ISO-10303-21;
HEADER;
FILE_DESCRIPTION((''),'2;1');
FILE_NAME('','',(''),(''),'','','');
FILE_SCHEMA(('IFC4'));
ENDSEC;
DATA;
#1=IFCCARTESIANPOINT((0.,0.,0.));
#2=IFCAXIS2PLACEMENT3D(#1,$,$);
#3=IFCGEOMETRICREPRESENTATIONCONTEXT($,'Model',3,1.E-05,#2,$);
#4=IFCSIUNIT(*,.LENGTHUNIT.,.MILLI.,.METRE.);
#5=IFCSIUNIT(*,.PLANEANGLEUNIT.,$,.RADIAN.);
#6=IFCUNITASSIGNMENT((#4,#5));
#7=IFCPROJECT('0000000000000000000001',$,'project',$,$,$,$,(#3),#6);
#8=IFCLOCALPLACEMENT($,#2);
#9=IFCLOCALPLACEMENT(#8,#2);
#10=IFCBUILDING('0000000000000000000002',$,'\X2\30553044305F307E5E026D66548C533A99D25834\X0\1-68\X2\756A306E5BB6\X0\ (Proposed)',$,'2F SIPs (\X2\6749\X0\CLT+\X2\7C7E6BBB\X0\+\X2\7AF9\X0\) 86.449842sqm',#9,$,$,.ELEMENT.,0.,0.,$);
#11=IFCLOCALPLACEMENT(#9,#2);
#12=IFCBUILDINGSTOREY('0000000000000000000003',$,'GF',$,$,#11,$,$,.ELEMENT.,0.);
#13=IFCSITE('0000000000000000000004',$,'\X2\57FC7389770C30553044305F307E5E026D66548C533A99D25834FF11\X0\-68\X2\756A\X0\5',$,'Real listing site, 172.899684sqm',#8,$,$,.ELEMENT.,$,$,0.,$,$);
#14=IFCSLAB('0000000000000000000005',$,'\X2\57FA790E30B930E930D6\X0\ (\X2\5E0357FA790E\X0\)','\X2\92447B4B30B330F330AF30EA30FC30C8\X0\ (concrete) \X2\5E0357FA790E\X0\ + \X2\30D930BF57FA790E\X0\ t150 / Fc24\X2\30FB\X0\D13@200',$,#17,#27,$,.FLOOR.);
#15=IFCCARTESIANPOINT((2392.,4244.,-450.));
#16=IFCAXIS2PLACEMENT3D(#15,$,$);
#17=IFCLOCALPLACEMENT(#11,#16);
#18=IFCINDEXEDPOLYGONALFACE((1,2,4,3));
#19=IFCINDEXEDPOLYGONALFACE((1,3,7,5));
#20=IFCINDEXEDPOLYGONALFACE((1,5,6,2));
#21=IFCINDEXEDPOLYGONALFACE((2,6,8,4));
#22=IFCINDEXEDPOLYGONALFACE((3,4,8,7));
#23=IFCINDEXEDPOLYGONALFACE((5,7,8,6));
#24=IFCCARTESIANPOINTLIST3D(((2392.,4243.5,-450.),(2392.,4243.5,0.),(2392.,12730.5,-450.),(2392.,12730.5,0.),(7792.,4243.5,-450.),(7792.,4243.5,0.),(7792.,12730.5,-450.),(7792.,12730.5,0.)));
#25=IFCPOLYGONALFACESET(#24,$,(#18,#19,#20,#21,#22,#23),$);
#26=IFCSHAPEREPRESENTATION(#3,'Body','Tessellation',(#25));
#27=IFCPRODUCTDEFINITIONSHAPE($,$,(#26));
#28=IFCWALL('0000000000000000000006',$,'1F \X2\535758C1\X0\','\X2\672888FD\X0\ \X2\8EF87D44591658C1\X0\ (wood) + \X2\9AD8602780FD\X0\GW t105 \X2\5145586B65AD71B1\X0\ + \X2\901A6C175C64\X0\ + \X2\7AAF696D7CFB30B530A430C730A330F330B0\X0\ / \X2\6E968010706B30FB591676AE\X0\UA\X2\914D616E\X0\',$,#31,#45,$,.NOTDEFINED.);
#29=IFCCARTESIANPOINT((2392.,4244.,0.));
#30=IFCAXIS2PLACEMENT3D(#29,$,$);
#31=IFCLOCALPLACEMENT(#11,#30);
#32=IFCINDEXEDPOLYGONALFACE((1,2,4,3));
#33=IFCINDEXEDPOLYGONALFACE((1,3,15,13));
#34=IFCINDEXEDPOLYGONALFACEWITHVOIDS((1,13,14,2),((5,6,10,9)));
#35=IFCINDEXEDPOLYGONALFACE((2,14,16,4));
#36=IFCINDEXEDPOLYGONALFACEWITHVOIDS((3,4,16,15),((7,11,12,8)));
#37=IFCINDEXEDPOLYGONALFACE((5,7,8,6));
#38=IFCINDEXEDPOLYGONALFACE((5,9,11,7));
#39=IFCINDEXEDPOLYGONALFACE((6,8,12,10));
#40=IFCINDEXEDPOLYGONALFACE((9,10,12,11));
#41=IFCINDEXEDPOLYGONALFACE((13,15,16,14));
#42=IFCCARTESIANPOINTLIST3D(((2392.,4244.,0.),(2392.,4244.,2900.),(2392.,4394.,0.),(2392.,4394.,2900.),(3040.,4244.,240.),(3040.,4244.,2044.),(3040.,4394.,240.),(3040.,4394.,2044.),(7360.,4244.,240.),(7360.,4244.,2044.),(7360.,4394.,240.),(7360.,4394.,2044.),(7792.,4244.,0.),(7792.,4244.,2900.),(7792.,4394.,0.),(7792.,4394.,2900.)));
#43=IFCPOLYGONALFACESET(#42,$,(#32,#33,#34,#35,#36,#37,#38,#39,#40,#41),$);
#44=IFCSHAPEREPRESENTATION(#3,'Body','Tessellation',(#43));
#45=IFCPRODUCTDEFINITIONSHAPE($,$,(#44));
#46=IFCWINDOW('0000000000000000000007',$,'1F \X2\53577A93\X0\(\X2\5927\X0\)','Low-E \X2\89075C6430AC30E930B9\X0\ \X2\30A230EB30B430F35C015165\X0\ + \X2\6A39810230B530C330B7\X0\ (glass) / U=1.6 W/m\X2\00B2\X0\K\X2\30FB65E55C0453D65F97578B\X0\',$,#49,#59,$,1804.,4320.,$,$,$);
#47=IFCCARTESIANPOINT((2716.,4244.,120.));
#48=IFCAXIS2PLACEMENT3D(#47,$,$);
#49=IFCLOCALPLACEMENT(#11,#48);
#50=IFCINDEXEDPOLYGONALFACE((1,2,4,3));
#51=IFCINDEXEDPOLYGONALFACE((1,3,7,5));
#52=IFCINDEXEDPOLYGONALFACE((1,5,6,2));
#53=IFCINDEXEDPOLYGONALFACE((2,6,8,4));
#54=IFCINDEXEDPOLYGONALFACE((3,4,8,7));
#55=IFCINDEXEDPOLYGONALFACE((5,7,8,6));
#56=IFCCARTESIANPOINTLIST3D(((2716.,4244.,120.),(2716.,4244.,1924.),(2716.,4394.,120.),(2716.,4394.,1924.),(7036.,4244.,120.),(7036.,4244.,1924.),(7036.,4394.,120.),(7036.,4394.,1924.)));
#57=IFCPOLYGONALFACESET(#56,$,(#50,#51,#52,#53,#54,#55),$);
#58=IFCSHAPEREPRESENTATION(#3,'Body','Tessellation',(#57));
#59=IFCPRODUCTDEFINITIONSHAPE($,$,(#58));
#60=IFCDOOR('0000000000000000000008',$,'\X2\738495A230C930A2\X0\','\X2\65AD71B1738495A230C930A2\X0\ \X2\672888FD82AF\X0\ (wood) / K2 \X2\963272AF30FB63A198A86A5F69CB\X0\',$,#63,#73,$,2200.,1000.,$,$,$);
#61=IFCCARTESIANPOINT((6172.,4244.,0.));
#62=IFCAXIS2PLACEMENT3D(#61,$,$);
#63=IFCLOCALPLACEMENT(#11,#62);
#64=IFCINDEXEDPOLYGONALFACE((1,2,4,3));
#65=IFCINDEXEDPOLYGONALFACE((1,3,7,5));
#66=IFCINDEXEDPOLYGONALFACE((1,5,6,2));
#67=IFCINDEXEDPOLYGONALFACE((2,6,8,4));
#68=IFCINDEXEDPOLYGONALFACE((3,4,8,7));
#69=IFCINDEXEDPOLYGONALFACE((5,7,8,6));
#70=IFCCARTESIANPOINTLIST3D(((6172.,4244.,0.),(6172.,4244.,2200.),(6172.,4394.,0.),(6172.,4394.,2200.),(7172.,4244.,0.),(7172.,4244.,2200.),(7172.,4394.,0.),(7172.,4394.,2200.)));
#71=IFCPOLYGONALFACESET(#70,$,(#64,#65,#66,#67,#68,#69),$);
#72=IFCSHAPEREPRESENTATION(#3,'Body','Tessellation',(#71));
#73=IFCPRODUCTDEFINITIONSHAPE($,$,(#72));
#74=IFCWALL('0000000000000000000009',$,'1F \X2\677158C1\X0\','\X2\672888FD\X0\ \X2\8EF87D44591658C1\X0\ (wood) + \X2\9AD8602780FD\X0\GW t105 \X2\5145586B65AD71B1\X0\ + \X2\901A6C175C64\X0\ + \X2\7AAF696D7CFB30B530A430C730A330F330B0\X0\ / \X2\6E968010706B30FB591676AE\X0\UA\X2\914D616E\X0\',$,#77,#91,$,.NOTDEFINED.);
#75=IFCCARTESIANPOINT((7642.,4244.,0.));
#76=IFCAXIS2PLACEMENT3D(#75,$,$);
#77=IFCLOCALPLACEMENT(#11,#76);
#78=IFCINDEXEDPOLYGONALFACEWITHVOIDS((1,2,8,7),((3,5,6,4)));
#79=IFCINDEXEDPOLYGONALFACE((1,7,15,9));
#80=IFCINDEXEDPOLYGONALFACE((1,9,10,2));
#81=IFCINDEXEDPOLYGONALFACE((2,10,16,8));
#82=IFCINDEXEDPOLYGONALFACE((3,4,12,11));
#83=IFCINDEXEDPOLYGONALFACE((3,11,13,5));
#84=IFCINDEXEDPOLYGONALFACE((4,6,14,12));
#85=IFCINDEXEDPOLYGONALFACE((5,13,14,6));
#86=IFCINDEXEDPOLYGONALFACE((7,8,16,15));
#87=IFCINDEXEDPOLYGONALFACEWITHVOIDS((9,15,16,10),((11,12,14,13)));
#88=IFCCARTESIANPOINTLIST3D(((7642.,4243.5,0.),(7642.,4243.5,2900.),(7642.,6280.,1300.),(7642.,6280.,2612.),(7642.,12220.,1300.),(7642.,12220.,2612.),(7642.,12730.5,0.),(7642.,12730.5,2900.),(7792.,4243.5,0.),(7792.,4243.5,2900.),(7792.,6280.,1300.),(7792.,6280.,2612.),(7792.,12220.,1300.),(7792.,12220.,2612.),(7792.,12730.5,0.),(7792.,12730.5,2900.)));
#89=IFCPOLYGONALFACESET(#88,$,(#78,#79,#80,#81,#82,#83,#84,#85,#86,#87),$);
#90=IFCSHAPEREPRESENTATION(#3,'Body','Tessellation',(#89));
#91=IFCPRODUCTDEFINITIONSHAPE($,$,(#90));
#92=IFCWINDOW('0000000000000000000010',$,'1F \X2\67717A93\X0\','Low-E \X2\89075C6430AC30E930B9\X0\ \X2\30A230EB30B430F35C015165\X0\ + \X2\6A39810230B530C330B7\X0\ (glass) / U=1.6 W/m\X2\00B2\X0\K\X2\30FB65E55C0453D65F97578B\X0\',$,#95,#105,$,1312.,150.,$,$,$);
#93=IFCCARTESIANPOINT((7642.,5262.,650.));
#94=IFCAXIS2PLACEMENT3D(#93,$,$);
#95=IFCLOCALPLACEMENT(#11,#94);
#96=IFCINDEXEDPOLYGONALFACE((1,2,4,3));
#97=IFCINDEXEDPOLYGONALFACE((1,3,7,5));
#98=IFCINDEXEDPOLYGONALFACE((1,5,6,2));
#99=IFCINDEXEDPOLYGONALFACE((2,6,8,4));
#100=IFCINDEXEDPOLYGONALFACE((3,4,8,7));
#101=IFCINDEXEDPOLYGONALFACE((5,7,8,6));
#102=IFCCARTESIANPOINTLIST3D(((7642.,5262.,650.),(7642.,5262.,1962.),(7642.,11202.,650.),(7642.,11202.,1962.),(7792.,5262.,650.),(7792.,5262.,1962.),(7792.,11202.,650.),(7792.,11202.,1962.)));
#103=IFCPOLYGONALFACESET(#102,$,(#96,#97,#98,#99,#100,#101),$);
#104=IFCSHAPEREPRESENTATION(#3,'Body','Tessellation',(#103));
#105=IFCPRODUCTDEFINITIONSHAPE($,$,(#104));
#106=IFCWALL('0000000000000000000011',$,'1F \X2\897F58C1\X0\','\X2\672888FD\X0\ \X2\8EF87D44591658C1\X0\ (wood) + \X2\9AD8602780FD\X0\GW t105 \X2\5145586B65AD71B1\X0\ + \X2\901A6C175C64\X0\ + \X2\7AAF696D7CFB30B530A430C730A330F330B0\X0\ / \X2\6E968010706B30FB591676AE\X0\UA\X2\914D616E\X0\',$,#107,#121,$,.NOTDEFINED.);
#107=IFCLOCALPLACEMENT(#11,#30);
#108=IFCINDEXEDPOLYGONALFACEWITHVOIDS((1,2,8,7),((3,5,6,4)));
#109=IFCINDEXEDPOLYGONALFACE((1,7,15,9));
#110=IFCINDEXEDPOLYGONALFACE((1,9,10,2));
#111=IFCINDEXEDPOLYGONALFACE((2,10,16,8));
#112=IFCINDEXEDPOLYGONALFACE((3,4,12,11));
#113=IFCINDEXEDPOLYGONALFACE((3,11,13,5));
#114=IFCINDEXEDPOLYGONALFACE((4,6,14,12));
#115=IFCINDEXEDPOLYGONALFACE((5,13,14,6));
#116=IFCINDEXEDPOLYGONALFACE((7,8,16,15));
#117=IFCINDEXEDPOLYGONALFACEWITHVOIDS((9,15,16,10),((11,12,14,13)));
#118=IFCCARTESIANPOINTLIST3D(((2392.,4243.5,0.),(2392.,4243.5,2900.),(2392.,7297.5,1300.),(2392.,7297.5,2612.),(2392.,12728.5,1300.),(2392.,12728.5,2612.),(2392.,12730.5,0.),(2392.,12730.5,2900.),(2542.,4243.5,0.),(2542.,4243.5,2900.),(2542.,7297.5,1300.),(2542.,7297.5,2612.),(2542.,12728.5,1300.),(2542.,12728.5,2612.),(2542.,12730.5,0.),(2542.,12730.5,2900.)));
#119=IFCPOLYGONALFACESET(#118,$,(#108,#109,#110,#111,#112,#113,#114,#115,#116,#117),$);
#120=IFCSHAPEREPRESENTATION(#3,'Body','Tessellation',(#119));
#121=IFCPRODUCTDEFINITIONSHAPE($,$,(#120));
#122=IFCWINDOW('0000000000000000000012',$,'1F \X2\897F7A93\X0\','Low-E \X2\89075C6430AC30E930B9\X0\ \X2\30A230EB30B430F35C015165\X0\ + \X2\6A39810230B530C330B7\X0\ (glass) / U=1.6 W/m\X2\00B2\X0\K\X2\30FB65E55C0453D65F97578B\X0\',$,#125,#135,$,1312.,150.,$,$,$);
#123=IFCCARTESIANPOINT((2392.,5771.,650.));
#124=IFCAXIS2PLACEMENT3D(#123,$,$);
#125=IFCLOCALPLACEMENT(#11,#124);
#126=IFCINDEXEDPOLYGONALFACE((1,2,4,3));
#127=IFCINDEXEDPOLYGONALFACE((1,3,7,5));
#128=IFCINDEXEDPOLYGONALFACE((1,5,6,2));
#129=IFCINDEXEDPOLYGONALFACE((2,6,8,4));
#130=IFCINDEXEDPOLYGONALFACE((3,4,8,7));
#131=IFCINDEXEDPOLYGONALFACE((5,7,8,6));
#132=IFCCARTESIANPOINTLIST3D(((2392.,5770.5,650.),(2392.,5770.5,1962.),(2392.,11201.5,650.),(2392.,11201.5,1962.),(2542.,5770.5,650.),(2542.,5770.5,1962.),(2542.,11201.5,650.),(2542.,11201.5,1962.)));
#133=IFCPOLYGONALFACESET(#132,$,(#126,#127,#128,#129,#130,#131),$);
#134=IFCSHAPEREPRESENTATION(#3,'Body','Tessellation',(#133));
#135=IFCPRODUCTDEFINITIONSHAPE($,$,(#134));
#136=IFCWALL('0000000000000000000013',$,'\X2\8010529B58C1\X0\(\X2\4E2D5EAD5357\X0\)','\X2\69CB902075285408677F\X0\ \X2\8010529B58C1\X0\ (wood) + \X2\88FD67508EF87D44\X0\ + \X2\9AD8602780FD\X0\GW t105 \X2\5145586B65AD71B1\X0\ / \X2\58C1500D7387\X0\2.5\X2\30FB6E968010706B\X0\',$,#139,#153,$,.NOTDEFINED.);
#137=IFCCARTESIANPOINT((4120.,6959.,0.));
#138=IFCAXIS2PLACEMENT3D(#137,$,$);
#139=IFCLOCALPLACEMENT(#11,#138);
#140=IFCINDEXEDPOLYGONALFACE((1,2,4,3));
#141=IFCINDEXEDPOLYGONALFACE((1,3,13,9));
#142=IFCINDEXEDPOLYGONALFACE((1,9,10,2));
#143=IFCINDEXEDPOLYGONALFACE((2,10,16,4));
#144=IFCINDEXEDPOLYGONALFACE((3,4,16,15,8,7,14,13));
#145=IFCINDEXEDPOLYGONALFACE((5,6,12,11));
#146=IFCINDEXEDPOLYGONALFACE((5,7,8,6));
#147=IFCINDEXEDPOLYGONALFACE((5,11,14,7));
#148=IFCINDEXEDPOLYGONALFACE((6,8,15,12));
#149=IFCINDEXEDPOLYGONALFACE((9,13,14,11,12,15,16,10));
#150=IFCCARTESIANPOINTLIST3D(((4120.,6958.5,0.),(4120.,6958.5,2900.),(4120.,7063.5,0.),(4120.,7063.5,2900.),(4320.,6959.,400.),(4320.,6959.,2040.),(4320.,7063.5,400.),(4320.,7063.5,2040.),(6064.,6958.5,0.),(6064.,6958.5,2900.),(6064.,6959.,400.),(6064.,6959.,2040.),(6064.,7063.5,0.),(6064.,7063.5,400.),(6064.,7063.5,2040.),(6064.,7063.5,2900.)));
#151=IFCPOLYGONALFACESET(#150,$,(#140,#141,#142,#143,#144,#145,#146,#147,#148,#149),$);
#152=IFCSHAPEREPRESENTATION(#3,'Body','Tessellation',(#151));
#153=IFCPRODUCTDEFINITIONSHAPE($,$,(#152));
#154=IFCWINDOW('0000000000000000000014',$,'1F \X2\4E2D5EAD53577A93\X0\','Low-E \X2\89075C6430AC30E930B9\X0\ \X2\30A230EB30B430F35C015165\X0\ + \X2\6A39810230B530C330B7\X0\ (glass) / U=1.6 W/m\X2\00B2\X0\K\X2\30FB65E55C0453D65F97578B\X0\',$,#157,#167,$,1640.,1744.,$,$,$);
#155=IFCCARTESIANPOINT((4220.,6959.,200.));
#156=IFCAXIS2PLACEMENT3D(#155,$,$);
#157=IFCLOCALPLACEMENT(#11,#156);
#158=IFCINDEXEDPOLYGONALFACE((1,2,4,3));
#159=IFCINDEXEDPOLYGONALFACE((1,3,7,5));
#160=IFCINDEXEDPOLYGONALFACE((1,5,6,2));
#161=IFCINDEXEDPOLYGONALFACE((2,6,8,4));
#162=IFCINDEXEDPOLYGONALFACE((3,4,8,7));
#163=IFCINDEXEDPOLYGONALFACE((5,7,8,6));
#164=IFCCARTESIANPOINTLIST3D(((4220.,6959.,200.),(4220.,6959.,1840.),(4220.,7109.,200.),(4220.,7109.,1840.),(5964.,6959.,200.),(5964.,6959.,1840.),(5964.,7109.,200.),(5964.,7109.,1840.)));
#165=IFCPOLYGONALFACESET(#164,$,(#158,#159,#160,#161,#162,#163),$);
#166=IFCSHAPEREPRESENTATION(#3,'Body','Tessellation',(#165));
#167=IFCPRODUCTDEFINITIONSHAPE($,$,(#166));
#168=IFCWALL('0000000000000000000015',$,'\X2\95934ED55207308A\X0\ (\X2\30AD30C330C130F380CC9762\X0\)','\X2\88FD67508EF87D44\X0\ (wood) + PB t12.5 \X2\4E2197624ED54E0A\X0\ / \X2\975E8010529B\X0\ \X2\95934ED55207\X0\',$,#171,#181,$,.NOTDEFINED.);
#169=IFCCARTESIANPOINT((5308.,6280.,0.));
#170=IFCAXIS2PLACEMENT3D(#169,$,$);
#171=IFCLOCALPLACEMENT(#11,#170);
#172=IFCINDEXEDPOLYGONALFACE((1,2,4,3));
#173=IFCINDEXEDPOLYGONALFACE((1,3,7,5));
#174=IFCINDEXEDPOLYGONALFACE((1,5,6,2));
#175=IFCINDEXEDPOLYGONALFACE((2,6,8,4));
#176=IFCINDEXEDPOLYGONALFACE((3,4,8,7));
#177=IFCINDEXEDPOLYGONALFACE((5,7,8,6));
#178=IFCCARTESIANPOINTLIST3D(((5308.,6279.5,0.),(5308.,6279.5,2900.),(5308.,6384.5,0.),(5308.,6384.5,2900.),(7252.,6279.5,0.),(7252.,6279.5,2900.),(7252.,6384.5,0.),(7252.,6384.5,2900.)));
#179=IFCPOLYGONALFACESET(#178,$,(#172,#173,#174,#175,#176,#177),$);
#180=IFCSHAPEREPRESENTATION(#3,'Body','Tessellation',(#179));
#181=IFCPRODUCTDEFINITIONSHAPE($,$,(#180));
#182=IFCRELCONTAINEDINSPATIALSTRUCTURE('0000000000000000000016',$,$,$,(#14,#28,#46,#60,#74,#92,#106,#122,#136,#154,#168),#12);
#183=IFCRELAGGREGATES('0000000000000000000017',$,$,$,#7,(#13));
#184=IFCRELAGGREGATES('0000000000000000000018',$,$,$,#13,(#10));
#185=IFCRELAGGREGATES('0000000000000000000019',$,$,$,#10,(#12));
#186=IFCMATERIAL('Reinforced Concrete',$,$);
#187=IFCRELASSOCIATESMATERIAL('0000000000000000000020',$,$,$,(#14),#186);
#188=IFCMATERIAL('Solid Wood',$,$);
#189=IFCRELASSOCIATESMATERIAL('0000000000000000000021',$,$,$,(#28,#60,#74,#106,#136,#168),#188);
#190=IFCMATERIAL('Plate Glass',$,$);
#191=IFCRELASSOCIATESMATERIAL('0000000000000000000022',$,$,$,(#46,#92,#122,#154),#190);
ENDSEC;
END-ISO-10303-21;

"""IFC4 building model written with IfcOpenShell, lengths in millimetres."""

from ifc_helpers import new_model, si_unit, frame, frame_2d, origin, place, context, project, spatial, rectangle, extrude, material, element, fill, save


model = new_model("IFC4")

# Units and contexts
model_context = context("Model", 3, precision=1e-05, world=origin())
ifc_project = project(units=[si_unit("LENGTHUNIT", "METRE", prefix="MILLI"), si_unit("PLANEANGLEUNIT", "RADIAN")], contexts=[model_context])

# Site, building, storey
site_placement = place(None, origin())
site = spatial("IfcSite", under=ifc_project, at=site_placement, Name="埼玉県さいたま市浦和区駒場１-68番5", ObjectType="Real listing site, 172.899684sqm", CompositionType="ELEMENT", RefElevation=0.0)
building_placement = place(site_placement, origin())
building = spatial("IfcBuilding", under=site, at=building_placement, Name="さいたま市浦和区駒場1-68番の家 (Proposed)", ObjectType="2F SIPs (杉CLT+籾殻+竹) 86.449842sqm", CompositionType="ELEMENT", ElevationOfRefHeight=0.0, ElevationOfTerrain=0.0)
storey_placement = place(building_placement, origin())
storey = spatial("IfcBuildingStorey", under=building, at=storey_placement, Name="GF", CompositionType="ELEMENT", Elevation=0.0)

# Slab
ifc_material_1 = material(Name="Reinforced Concrete")
slab_1_placement = place(storey_placement, frame((2392.0, 4244.0, -450.0)))
element("IfcSlab", 1, at=slab_1_placement, inside=storey, material=ifc_material_1, Name="基礎スラブ (布基礎)", Description="鉄筋コンクリート (concrete) 布基礎 + ベタ基礎 t150 / Fc24・D13@200", PredefinedType="FLOOR", context=model_context, shape_type="SweptSolid", body=[
    extrude(rectangle(XDim=5400.0, YDim=8487.0, at=frame_2d((2700.0, 4243.0))), frame((2392.0, 4244.0, -450.0)), (0.0, 0.0, 1.0), 450.0),
])
ifc_material_2 = material(Name="Solid Wood")

# Wall, openings, window, door
wall_1_placement = place(storey_placement, frame((2392.0, 4244.0, 0.0)))
wall_1 = element("IfcWall", 2, at=wall_1_placement, inside=storey, material=ifc_material_2, Name="1F 南壁", Description="木製 軸組外壁 (wood) + 高性能GW t105 充填断熱 + 通気層 + 窯業系サイディング / 準耐火・外皮UA配慮", PredefinedType="NOTDEFINED", context=model_context, shape_type="SweptSolid", body=[
    extrude(rectangle(XDim=5400.0, YDim=150.0, at=frame_2d((2700.0, 75.0))), frame((2392.0, 4244.0, 0.0)), (0.0, 0.0, 1.0), 2900.0),
])
opening_1_placement = place(storey_placement, frame((2716.0, 4244.0, 120.0)))
opening_1 = element("IfcOpeningElement", 3, at=opening_1_placement, cuts=wall_1, PredefinedType="NOTDEFINED", context=model_context, shape_type="SweptSolid", body=[
    extrude(rectangle(XDim=4320.0, YDim=150.0, at=frame_2d((2160.0, 75.0))), frame((2716.0, 4244.0, 120.0)), (0.0, 0.0, 1.0), 1804.0),
])
opening_2_placement = place(storey_placement, frame((6172.0, 4244.0, 0.0)))
opening_2 = element("IfcOpeningElement", 4, at=opening_2_placement, cuts=wall_1, PredefinedType="NOTDEFINED", context=model_context, shape_type="SweptSolid", body=[
    extrude(rectangle(XDim=1000.0, YDim=150.0, at=frame_2d((500.0, 75.0))), frame((6172.0, 4244.0, 0.0)), (0.0, 0.0, 1.0), 2200.0),
])
ifc_material_3 = material(Name="Plate Glass")
window_1_placement = place(storey_placement, frame((2716.0, 4244.0, 120.0)))
window_1 = element("IfcWindow", 5, at=window_1_placement, inside=storey, material=ifc_material_3, Name="1F 南窓(大)", Description="Low-E 複層ガラス アルゴン封入 + 樹脂サッシ (glass) / U=1.6 W/m²K・日射取得型", OverallHeight=1804.0, OverallWidth=4320.0, context=model_context, shape_type="SweptSolid", body=[
    extrude(rectangle(XDim=4320.0, YDim=150.0, at=frame_2d((2160.0, 75.0))), frame((2716.0, 4244.0, 120.0)), (0.0, 0.0, 1.0), 1804.0),
])
fill(opening_1, window_1)
door_placement = place(storey_placement, frame((6172.0, 4244.0, 0.0)))
door = element("IfcDoor", 6, at=door_placement, inside=storey, material=ifc_material_2, Name="玄関ドア", Description="断熱玄関ドア 木製芯 (wood) / K2 防犯・採風機構", OverallHeight=2200.0, OverallWidth=1000.0, context=model_context, shape_type="SweptSolid", body=[
    extrude(rectangle(XDim=1000.0, YDim=150.0, at=frame_2d((500.0, 75.0))), frame((6172.0, 4244.0, 0.0)), (0.0, 0.0, 1.0), 2200.0),
])
fill(opening_2, door)

# Walls, openings, windows
wall_2_placement = place(storey_placement, frame((7642.0, 4244.0, 0.0)))
wall_2 = element("IfcWall", 7, at=wall_2_placement, inside=storey, material=ifc_material_2, Name="1F 東壁", Description="木製 軸組外壁 (wood) + 高性能GW t105 充填断熱 + 通気層 + 窯業系サイディング / 準耐火・外皮UA配慮", PredefinedType="NOTDEFINED", context=model_context, shape_type="SweptSolid", body=[
    extrude(rectangle(XDim=150.0, YDim=8487.0, at=frame_2d((75.0, 4243.0))), frame((7642.0, 4244.0, 0.0)), (0.0, 0.0, 1.0), 2900.0),
])
opening_3_placement = place(storey_placement, frame((7642.0, 5262.0, 650.0)))
opening_3 = element("IfcOpeningElement", 8, at=opening_3_placement, cuts=wall_2, PredefinedType="NOTDEFINED", context=model_context, shape_type="SweptSolid", body=[
    extrude(rectangle(XDim=150.0, YDim=5940.0, at=frame_2d((75.0, 2970.0))), frame((7642.0, 5262.0, 650.0)), (0.0, 0.0, 1.0), 1312.0),
])
window_2_placement = place(storey_placement, frame((7642.0, 5262.0, 650.0)))
window_2 = element("IfcWindow", 9, at=window_2_placement, inside=storey, material=ifc_material_3, Name="1F 東窓", Description="Low-E 複層ガラス アルゴン封入 + 樹脂サッシ (glass) / U=1.6 W/m²K・日射取得型", OverallHeight=1312.0, OverallWidth=150.0, context=model_context, shape_type="SweptSolid", body=[
    extrude(rectangle(XDim=150.0, YDim=5940.0, at=frame_2d((75.0, 2970.0))), frame((7642.0, 5262.0, 650.0)), (0.0, 0.0, 1.0), 1312.0),
])
fill(opening_3, window_2)
wall_3_placement = place(storey_placement, frame((2392.0, 4244.0, 0.0)))
wall_3 = element("IfcWall", 10, at=wall_3_placement, inside=storey, material=ifc_material_2, Name="1F 西壁", Description="木製 軸組外壁 (wood) + 高性能GW t105 充填断熱 + 通気層 + 窯業系サイディング / 準耐火・外皮UA配慮", PredefinedType="NOTDEFINED", context=model_context, shape_type="SweptSolid", body=[
    extrude(rectangle(XDim=150.0, YDim=8487.0, at=frame_2d((75.0, 4243.0))), frame((2392.0, 4244.0, 0.0)), (0.0, 0.0, 1.0), 2900.0),
])
opening_4_placement = place(storey_placement, frame((2392.0, 5771.0, 650.0)))
opening_4 = element("IfcOpeningElement", 11, at=opening_4_placement, cuts=wall_3, PredefinedType="NOTDEFINED", context=model_context, shape_type="SweptSolid", body=[
    extrude(rectangle(XDim=150.0, YDim=5431.0, at=frame_2d((75.0, 2715.0))), frame((2392.0, 5771.0, 650.0)), (0.0, 0.0, 1.0), 1312.0),
])
window_3_placement = place(storey_placement, frame((2392.0, 5771.0, 650.0)))
window_3 = element("IfcWindow", 12, at=window_3_placement, inside=storey, material=ifc_material_3, Name="1F 西窓", Description="Low-E 複層ガラス アルゴン封入 + 樹脂サッシ (glass) / U=1.6 W/m²K・日射取得型", OverallHeight=1312.0, OverallWidth=150.0, context=model_context, shape_type="SweptSolid", body=[
    extrude(rectangle(XDim=150.0, YDim=5431.0, at=frame_2d((75.0, 2715.0))), frame((2392.0, 5771.0, 650.0)), (0.0, 0.0, 1.0), 1312.0),
])
fill(opening_4, window_3)
wall_4_placement = place(storey_placement, frame((4120.0, 6959.0, 0.0)))
wall_4 = element("IfcWall", 13, at=wall_4_placement, inside=storey, material=ifc_material_2, Name="耐力壁(中庭南)", Description="構造用合板 耐力壁 (wood) + 製材軸組 + 高性能GW t105 充填断熱 / 壁倍率2.5・準耐火", PredefinedType="NOTDEFINED", context=model_context, shape_type="SweptSolid", body=[
    extrude(rectangle(XDim=1944.0, YDim=105.0, at=frame_2d((972.0, 52.0))), frame((4120.0, 6959.0, 0.0)), (0.0, 0.0, 1.0), 2900.0),
])
opening_5_placement = place(storey_placement, frame((4220.0, 6959.0, 200.0)))
opening_5 = element("IfcOpeningElement", 14, at=opening_5_placement, cuts=wall_4, PredefinedType="NOTDEFINED", context=model_context, shape_type="SweptSolid", body=[
    extrude(rectangle(XDim=1744.0, YDim=150.0, at=frame_2d((872.0, 75.0))), frame((4220.0, 6959.0, 200.0)), (0.0, 0.0, 1.0), 1640.0),
])
window_4_placement = place(storey_placement, frame((4220.0, 6959.0, 200.0)))
window_4 = element("IfcWindow", 15, at=window_4_placement, inside=storey, material=ifc_material_3, Name="1F 中庭南窓", Description="Low-E 複層ガラス アルゴン封入 + 樹脂サッシ (glass) / U=1.6 W/m²K・日射取得型", OverallHeight=1640.0, OverallWidth=1744.0, context=model_context, shape_type="SweptSolid", body=[
    extrude(rectangle(XDim=1744.0, YDim=150.0, at=frame_2d((872.0, 75.0))), frame((4220.0, 6959.0, 200.0)), (0.0, 0.0, 1.0), 1640.0),
])
fill(opening_5, window_4)

# Wall
wall_5_placement = place(storey_placement, frame((5308.0, 6280.0, 0.0)))
element("IfcWall", 16, at=wall_5_placement, inside=storey, material=ifc_material_2, Name="間仕切り (キッチン背面)", Description="製材軸組 (wood) + PB t12.5 両面仕上 / 非耐力 間仕切", PredefinedType="NOTDEFINED", context=model_context, shape_type="SweptSolid", body=[
    extrude(rectangle(XDim=1944.0, YDim=105.0, at=frame_2d((972.0, 52.0))), frame((5308.0, 6280.0, 0.0)), (0.0, 0.0, 1.0), 2900.0),
])

save(model, "model.ifc")
